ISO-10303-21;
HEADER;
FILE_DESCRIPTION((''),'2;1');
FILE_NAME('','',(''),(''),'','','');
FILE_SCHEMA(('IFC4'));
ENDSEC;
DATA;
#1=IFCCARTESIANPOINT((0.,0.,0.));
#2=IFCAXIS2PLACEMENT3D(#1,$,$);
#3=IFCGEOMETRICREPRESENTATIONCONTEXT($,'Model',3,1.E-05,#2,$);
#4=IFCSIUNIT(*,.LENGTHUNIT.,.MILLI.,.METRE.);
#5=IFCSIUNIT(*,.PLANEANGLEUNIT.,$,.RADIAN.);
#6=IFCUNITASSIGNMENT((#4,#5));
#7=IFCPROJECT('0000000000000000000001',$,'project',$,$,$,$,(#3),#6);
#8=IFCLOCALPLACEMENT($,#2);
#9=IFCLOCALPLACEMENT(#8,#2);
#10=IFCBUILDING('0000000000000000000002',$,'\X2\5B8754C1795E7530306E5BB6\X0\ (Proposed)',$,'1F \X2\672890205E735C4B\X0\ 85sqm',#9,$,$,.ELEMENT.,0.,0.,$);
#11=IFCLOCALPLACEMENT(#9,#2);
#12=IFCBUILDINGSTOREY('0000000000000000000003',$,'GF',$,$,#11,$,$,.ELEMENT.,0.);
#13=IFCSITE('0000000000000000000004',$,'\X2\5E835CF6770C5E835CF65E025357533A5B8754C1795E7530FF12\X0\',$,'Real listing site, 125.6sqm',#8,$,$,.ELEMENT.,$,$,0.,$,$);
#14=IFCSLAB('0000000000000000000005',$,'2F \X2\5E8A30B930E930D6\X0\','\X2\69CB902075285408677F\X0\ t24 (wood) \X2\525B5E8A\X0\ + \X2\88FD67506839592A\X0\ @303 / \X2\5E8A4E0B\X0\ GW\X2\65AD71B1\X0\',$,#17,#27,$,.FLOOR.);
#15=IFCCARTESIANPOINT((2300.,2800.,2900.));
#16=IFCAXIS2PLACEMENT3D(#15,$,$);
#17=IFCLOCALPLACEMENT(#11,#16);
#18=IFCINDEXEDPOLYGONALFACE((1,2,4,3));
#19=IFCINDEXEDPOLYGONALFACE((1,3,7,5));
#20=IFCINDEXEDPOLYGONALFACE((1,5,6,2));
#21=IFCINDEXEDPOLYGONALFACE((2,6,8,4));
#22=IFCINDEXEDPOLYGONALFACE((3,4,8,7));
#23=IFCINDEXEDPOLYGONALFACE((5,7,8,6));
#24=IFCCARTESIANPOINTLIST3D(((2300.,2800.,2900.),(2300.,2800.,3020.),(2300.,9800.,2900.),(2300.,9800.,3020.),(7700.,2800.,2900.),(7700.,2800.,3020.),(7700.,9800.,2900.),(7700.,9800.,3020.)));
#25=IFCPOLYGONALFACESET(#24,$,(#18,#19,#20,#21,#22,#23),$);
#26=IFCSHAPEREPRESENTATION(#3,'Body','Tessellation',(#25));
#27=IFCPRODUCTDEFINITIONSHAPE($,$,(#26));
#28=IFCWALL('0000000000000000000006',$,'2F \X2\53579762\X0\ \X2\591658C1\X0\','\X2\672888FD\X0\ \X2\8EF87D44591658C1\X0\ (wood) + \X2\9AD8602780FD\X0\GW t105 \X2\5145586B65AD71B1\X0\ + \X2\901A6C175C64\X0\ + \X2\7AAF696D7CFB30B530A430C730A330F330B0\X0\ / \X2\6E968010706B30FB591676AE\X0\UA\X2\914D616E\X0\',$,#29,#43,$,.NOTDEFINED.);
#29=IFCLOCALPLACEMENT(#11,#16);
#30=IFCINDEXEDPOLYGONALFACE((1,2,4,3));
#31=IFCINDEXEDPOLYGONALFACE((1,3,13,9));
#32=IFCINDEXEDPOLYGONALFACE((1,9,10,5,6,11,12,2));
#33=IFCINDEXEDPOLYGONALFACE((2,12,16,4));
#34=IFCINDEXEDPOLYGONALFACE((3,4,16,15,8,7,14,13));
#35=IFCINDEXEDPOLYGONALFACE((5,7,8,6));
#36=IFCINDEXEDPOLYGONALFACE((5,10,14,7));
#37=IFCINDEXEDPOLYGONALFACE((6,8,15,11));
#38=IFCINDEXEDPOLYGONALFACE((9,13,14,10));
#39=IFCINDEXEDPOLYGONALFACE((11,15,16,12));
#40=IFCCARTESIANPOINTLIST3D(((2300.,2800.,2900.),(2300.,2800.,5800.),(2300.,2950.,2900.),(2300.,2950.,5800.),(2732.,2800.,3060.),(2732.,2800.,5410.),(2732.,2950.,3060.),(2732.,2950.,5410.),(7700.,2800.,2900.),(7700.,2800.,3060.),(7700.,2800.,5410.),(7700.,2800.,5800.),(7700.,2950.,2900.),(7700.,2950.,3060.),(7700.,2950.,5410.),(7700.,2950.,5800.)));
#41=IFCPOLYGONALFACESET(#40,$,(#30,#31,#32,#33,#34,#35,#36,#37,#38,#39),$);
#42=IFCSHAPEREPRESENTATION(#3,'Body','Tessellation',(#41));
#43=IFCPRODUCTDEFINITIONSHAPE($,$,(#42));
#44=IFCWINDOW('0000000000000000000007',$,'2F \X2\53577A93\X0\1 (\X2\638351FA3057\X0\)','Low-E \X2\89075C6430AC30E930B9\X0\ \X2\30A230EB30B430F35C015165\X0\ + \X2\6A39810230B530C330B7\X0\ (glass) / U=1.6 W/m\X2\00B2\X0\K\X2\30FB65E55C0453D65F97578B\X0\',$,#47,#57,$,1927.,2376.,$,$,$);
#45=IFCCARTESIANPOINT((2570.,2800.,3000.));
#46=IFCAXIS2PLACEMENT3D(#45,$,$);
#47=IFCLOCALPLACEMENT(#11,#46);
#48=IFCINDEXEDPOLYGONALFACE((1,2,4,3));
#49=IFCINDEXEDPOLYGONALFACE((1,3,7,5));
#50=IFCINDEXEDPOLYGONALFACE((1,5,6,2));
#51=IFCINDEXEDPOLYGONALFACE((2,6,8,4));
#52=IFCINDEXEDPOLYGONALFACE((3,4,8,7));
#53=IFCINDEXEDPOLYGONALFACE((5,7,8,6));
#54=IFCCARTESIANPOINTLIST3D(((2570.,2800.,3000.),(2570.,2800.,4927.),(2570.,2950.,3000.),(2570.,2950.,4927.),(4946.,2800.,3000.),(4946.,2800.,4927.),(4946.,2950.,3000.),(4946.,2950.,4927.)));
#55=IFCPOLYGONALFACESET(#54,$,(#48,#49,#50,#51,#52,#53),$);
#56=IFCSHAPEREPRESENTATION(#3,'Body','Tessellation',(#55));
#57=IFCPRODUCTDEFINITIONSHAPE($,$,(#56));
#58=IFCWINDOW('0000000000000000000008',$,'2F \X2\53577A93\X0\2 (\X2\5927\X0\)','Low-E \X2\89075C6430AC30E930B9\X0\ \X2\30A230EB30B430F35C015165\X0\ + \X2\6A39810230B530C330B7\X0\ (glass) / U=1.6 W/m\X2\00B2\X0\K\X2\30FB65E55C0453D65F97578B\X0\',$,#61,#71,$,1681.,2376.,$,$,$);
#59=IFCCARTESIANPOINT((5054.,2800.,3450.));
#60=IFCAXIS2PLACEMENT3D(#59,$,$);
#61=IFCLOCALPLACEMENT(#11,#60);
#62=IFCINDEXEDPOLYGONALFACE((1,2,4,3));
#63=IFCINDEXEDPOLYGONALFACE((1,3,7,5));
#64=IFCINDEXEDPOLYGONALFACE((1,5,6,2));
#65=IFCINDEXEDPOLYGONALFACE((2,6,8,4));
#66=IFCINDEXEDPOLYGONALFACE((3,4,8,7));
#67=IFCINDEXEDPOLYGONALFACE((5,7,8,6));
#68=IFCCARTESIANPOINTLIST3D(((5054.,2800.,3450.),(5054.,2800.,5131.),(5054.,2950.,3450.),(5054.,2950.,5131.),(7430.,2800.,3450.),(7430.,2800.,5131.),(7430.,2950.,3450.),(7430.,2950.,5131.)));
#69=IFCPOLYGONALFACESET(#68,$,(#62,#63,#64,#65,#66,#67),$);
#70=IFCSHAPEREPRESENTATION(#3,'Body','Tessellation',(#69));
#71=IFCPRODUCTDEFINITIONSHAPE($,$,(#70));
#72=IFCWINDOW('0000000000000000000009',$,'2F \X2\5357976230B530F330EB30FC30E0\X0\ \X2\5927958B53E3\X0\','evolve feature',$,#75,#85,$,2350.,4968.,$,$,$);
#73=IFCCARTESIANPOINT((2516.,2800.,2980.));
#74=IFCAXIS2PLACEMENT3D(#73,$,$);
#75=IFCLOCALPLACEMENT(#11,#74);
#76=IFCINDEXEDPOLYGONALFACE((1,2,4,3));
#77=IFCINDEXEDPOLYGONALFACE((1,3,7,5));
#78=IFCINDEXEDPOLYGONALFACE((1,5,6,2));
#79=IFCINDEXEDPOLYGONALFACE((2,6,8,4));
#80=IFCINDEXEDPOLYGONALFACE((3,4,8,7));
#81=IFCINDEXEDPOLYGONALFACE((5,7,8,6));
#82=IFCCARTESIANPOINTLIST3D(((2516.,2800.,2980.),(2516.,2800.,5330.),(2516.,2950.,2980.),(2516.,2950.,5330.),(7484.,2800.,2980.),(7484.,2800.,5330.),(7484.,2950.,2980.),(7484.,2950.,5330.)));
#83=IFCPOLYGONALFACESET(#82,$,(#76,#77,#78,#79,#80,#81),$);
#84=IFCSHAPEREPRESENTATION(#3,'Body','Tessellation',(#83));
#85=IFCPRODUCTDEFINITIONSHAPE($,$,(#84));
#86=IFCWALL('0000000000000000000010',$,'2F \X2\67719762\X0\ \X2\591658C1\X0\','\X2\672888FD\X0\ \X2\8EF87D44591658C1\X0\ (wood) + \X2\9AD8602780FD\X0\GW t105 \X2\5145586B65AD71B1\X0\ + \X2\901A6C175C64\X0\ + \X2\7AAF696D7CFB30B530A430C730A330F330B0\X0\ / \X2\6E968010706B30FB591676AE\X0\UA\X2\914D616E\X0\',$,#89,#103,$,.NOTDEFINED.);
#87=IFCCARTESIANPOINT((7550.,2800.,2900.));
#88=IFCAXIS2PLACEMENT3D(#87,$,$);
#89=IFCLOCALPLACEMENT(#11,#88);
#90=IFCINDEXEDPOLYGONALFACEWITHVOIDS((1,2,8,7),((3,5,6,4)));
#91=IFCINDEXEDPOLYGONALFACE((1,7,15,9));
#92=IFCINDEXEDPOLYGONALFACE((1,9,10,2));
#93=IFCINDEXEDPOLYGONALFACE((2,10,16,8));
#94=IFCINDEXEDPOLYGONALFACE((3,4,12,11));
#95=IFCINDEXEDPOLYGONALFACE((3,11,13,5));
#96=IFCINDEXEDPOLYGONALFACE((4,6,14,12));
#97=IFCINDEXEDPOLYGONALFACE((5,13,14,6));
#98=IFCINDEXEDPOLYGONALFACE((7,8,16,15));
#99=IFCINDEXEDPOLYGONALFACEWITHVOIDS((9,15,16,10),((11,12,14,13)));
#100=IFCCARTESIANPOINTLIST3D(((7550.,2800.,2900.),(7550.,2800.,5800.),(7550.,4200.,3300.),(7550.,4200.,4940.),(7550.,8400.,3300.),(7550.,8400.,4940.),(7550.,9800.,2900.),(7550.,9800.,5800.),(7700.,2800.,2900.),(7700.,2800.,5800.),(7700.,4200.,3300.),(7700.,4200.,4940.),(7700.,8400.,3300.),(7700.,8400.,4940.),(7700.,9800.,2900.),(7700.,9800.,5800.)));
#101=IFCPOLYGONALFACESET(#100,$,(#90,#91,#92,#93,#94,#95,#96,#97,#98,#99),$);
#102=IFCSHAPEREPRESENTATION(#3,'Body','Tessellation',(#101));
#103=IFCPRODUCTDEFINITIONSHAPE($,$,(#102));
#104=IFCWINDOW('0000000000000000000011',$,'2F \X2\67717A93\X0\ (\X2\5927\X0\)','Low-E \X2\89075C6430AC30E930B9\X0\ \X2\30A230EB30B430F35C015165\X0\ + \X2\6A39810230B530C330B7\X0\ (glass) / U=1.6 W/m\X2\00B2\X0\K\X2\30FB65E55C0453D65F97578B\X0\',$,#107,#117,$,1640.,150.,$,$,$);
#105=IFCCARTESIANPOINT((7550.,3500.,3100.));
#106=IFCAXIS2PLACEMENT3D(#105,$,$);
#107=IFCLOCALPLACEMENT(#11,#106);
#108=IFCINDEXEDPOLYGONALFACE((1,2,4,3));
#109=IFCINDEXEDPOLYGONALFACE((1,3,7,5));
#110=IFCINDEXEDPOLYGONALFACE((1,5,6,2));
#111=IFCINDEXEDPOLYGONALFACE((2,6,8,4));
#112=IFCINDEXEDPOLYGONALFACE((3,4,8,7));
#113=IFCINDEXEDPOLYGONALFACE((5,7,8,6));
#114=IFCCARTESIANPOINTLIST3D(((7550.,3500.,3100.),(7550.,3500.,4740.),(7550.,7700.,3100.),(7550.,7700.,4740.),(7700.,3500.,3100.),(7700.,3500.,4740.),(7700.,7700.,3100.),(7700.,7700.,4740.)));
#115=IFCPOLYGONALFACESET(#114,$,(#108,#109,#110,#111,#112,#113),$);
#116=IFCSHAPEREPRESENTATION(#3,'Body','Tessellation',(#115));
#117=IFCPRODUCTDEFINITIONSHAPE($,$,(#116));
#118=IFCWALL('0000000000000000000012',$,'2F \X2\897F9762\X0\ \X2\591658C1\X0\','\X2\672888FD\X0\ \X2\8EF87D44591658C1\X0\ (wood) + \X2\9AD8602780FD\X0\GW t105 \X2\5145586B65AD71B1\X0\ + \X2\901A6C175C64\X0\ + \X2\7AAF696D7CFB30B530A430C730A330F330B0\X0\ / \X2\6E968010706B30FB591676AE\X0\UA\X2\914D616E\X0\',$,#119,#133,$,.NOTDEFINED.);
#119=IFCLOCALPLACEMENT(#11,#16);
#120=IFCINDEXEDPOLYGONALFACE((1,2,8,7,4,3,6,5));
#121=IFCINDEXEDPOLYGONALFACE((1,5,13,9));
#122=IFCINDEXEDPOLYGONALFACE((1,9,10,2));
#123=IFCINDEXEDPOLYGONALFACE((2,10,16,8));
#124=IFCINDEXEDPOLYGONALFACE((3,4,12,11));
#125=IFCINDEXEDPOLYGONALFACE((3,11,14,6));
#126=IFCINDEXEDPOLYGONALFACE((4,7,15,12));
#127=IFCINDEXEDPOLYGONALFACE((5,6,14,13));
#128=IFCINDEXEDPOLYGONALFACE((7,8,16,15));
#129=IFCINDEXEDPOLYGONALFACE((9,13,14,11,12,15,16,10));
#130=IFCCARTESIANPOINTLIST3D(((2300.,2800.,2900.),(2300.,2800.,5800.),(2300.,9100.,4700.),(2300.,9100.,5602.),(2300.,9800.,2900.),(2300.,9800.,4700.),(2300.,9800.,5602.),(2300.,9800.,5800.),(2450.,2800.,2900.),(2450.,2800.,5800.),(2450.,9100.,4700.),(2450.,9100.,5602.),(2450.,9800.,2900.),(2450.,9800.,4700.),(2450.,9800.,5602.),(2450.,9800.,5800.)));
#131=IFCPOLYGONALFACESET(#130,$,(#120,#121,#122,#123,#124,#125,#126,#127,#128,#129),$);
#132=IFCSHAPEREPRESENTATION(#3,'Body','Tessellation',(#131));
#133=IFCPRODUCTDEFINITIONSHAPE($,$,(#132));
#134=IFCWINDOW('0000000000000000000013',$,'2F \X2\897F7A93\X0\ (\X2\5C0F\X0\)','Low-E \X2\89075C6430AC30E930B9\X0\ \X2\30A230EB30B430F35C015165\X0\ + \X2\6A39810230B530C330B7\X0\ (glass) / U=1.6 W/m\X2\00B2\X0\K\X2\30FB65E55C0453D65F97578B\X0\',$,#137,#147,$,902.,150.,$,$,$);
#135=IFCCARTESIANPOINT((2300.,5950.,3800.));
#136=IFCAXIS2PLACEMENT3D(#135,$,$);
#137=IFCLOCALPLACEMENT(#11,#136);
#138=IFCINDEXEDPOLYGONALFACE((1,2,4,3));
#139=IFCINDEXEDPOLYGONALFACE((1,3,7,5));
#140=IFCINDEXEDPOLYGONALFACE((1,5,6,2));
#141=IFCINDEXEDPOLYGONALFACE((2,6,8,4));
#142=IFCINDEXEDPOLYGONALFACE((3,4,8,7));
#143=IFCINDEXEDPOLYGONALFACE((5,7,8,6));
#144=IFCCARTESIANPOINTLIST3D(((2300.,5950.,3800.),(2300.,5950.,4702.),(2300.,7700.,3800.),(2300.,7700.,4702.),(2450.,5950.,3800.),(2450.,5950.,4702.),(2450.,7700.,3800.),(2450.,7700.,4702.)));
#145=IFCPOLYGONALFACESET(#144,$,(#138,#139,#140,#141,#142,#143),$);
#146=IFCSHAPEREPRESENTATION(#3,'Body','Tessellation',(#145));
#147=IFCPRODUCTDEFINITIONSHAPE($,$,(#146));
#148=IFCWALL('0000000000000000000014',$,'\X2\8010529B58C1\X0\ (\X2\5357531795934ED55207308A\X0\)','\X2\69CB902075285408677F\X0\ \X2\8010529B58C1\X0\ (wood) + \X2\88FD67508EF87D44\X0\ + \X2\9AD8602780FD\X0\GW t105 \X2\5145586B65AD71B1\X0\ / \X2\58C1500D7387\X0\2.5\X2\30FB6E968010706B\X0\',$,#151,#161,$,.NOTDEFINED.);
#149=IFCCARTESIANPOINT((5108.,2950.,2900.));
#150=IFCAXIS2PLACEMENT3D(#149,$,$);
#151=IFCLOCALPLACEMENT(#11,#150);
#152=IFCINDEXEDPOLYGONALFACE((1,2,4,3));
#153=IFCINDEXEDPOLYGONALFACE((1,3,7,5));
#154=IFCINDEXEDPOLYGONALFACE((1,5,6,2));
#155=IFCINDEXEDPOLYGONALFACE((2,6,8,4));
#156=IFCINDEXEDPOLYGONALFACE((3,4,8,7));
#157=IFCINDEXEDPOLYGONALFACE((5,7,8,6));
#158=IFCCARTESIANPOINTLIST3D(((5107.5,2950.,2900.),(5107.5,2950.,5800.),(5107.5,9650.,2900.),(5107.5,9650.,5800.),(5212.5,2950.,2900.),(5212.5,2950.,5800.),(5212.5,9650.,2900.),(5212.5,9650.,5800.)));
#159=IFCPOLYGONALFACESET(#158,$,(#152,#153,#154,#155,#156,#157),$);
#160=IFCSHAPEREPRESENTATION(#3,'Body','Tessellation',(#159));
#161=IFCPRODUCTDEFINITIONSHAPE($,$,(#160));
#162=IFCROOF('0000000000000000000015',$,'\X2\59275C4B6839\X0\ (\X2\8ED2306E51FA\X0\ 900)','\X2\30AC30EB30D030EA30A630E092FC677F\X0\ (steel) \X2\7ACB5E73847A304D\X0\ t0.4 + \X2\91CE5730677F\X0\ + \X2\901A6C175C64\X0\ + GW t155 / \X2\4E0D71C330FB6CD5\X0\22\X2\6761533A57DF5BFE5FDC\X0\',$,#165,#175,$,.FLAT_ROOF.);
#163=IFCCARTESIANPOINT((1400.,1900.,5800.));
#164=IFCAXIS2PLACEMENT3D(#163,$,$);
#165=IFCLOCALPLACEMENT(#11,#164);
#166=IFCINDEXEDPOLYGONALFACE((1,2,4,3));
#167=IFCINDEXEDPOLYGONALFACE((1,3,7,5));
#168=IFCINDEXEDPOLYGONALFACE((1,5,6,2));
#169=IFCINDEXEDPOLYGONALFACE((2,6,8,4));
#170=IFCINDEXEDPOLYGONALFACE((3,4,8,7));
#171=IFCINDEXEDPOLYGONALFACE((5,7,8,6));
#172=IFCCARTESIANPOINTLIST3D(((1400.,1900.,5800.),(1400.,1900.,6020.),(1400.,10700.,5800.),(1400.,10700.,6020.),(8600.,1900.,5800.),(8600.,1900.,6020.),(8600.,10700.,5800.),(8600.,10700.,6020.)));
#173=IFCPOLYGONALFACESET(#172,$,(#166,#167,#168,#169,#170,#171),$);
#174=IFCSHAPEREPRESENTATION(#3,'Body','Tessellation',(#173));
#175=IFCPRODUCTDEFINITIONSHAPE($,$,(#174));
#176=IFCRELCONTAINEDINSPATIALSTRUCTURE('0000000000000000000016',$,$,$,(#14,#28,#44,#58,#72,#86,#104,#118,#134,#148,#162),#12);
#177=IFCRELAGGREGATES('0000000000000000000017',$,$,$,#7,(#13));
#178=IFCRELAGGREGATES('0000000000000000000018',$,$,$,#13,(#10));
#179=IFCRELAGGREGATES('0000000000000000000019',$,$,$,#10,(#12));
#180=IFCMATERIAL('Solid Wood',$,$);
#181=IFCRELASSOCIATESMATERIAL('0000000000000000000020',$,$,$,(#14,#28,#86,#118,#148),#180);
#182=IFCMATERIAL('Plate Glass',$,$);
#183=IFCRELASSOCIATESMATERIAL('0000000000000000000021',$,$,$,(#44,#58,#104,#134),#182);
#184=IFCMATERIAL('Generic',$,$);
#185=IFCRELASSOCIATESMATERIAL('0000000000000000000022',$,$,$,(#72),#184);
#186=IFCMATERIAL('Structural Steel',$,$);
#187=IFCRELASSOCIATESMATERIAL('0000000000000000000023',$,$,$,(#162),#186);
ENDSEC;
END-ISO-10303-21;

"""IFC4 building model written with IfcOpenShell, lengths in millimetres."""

from ifc_helpers import new_model, si_unit, frame, frame_2d, origin, place, context, project, spatial, rectangle, extrude, material, element, fill, save


model = new_model("IFC4")

# Units and contexts
model_context = context("Model", 3, precision=1e-05, world=origin())
ifc_project = project(units=[si_unit("LENGTHUNIT", "METRE", prefix="MILLI"), si_unit("PLANEANGLEUNIT", "RADIAN")], contexts=[model_context])

# Site, building, storey
site_placement = place(None, origin())
site = spatial("IfcSite", under=ifc_project, at=site_placement, Name="広島県広島市南区宇品神田２", ObjectType="Real listing site, 125.6sqm", CompositionType="ELEMENT", RefElevation=0.0)
building_placement = place(site_placement, origin())
building = spatial("IfcBuilding", under=site, at=building_placement, Name="宇品神田の家 (Proposed)", ObjectType="1F 木造平屋 85sqm", CompositionType="ELEMENT", ElevationOfRefHeight=0.0, ElevationOfTerrain=0.0)
storey_placement = place(building_placement, origin())
storey = spatial("IfcBuildingStorey", under=building, at=storey_placement, Name="GF", CompositionType="ELEMENT", Elevation=0.0)

# Slab
ifc_material_1 = material(Name="Solid Wood")
slab_placement = place(storey_placement, frame((2300.0, 2800.0, 2900.0)))
element("IfcSlab", 1, at=slab_placement, inside=storey, material=ifc_material_1, Name="2F 床スラブ", Description="構造用合板 t24 (wood) 剛床 + 製材根太 @303 / 床下 GW断熱", PredefinedType="FLOOR", context=model_context, shape_type="SweptSolid", body=[
    extrude(rectangle(XDim=5400.0, YDim=7000.0, at=frame_2d((2700.0, 3500.0))), frame((2300.0, 2800.0, 2900.0)), (0.0, 0.0, 1.0), 120.0),
])

# Wall, openings, windows
wall_1_placement = place(storey_placement, frame((2300.0, 2800.0, 2900.0)))
wall_1 = element("IfcWall", 2, at=wall_1_placement, inside=storey, material=ifc_material_1, Name="2F 南面 外壁", Description="木製 軸組外壁 (wood) + 高性能GW t105 充填断熱 + 通気層 + 窯業系サイディング / 準耐火・外皮UA配慮", PredefinedType="NOTDEFINED", context=model_context, shape_type="SweptSolid", body=[
    extrude(rectangle(XDim=5400.0, YDim=150.0, at=frame_2d((2700.0, 75.0))), frame((2300.0, 2800.0, 2900.0)), (0.0, 0.0, 1.0), 2900.0),
])
opening_1_placement = place(storey_placement, frame((2570.0, 2800.0, 3000.0)))
opening_1 = element("IfcOpeningElement", 3, at=opening_1_placement, cuts=wall_1, PredefinedType="NOTDEFINED", context=model_context, shape_type="SweptSolid", body=[
    extrude(rectangle(XDim=2376.0, YDim=150.0, at=frame_2d((1188.0, 75.0))), frame((2570.0, 2800.0, 3000.0)), (0.0, 0.0, 1.0), 1927.0),
])
opening_2_placement = place(storey_placement, frame((5054.0, 2800.0, 3450.0)))
opening_2 = element("IfcOpeningElement", 4, at=opening_2_placement, cuts=wall_1, PredefinedType="NOTDEFINED", context=model_context, shape_type="SweptSolid", body=[
    extrude(rectangle(XDim=2376.0, YDim=150.0, at=frame_2d((1188.0, 75.0))), frame((5054.0, 2800.0, 3450.0)), (0.0, 0.0, 1.0), 1681.0),
])
opening_3_placement = place(storey_placement, frame((2516.0, 2800.0, 2980.0)))
opening_3 = element("IfcOpeningElement", 5, at=opening_3_placement, cuts=wall_1, PredefinedType="NOTDEFINED", context=model_context, shape_type="SweptSolid", body=[
    extrude(rectangle(XDim=4968.0, YDim=150.0, at=frame_2d((2484.0, 75.0))), frame((2516.0, 2800.0, 2980.0)), (0.0, 0.0, 1.0), 2350.0),
])
ifc_material_2 = material(Name="Plate Glass")
window_1_placement = place(storey_placement, frame((2570.0, 2800.0, 3000.0)))
window_1 = element("IfcWindow", 6, at=window_1_placement, inside=storey, material=ifc_material_2, Name="2F 南窓1 (掃出し)", Description="Low-E 複層ガラス アルゴン封入 + 樹脂サッシ (glass) / U=1.6 W/m²K・日射取得型", OverallHeight=1927.0, OverallWidth=2376.0, context=model_context, shape_type="SweptSolid", body=[
    extrude(rectangle(XDim=2376.0, YDim=150.0, at=frame_2d((1188.0, 75.0))), frame((2570.0, 2800.0, 3000.0)), (0.0, 0.0, 1.0), 1927.0),
])
fill(opening_1, window_1)
window_2_placement = place(storey_placement, frame((5054.0, 2800.0, 3450.0)))
window_2 = element("IfcWindow", 7, at=window_2_placement, inside=storey, material=ifc_material_2, Name="2F 南窓2 (大)", Description="Low-E 複層ガラス アルゴン封入 + 樹脂サッシ (glass) / U=1.6 W/m²K・日射取得型", OverallHeight=1681.0, OverallWidth=2376.0, context=model_context, shape_type="SweptSolid", body=[
    extrude(rectangle(XDim=2376.0, YDim=150.0, at=frame_2d((1188.0, 75.0))), frame((5054.0, 2800.0, 3450.0)), (0.0, 0.0, 1.0), 1681.0),
])
fill(opening_2, window_2)
ifc_material_3 = material(Name="Generic")
window_3_placement = place(storey_placement, frame((2516.0, 2800.0, 2980.0)))
window_3 = element("IfcWindow", 8, at=window_3_placement, inside=storey, material=ifc_material_3, Name="2F 南面サンルーム 大開口", Description="evolve feature", OverallHeight=2350.0, OverallWidth=4968.0, context=model_context, shape_type="SweptSolid", body=[
    extrude(rectangle(XDim=4968.0, YDim=150.0, at=frame_2d((2484.0, 75.0))), frame((2516.0, 2800.0, 2980.0)), (0.0, 0.0, 1.0), 2350.0),
])
fill(opening_3, window_3)

# Walls, openings, windows
wall_2_placement = place(storey_placement, frame((7550.0, 2800.0, 2900.0)))
wall_2 = element("IfcWall", 9, at=wall_2_placement, inside=storey, material=ifc_material_1, Name="2F 東面 外壁", Description="木製 軸組外壁 (wood) + 高性能GW t105 充填断熱 + 通気層 + 窯業系サイディング / 準耐火・外皮UA配慮", PredefinedType="NOTDEFINED", context=model_context, shape_type="SweptSolid", body=[
    extrude(rectangle(XDim=150.0, YDim=7000.0, at=frame_2d((75.0, 3500.0))), frame((7550.0, 2800.0, 2900.0)), (0.0, 0.0, 1.0), 2900.0),
])
opening_4_placement = place(storey_placement, frame((7550.0, 3500.0, 3100.0)))
opening_4 = element("IfcOpeningElement", 10, at=opening_4_placement, cuts=wall_2, PredefinedType="NOTDEFINED", context=model_context, shape_type="SweptSolid", body=[
    extrude(rectangle(XDim=150.0, YDim=4200.0, at=frame_2d((75.0, 2100.0))), frame((7550.0, 3500.0, 3100.0)), (0.0, 0.0, 1.0), 1640.0),
])
window_4_placement = place(storey_placement, frame((7550.0, 3500.0, 3100.0)))
window_4 = element("IfcWindow", 11, at=window_4_placement, inside=storey, material=ifc_material_2, Name="2F 東窓 (大)", Description="Low-E 複層ガラス アルゴン封入 + 樹脂サッシ (glass) / U=1.6 W/m²K・日射取得型", OverallHeight=1640.0, OverallWidth=150.0, context=model_context, shape_type="SweptSolid", body=[
    extrude(rectangle(XDim=150.0, YDim=4200.0, at=frame_2d((75.0, 2100.0))), frame((7550.0, 3500.0, 3100.0)), (0.0, 0.0, 1.0), 1640.0),
])
fill(opening_4, window_4)
wall_3_placement = place(storey_placement, frame((2300.0, 2800.0, 2900.0)))
wall_3 = element("IfcWall", 12, at=wall_3_placement, inside=storey, material=ifc_material_1, Name="2F 西面 外壁", Description="木製 軸組外壁 (wood) + 高性能GW t105 充填断熱 + 通気層 + 窯業系サイディング / 準耐火・外皮UA配慮", PredefinedType="NOTDEFINED", context=model_context, shape_type="SweptSolid", body=[
    extrude(rectangle(XDim=150.0, YDim=7000.0, at=frame_2d((75.0, 3500.0))), frame((2300.0, 2800.0, 2900.0)), (0.0, 0.0, 1.0), 2900.0),
])
opening_5_placement = place(storey_placement, frame((2300.0, 5950.0, 3800.0)))
opening_5 = element("IfcOpeningElement", 13, at=opening_5_placement, cuts=wall_3, PredefinedType="NOTDEFINED", context=model_context, shape_type="SweptSolid", body=[
    extrude(rectangle(XDim=150.0, YDim=1750.0, at=frame_2d((75.0, 875.0))), frame((2300.0, 5950.0, 3800.0)), (0.0, 0.0, 1.0), 902.0),
])
window_5_placement = place(storey_placement, frame((2300.0, 5950.0, 3800.0)))
window_5 = element("IfcWindow", 14, at=window_5_placement, inside=storey, material=ifc_material_2, Name="2F 西窓 (小)", Description="Low-E 複層ガラス アルゴン封入 + 樹脂サッシ (glass) / U=1.6 W/m²K・日射取得型", OverallHeight=902.0, OverallWidth=150.0, context=model_context, shape_type="SweptSolid", body=[
    extrude(rectangle(XDim=150.0, YDim=1750.0, at=frame_2d((75.0, 875.0))), frame((2300.0, 5950.0, 3800.0)), (0.0, 0.0, 1.0), 902.0),
])
fill(opening_5, window_5)

# Wall
wall_4_placement = place(storey_placement, frame((5108.0, 2950.0, 2900.0)))
element("IfcWall", 15, at=wall_4_placement, inside=storey, material=ifc_material_1, Name="耐力壁 (南北間仕切り)", Description="構造用合板 耐力壁 (wood) + 製材軸組 + 高性能GW t105 充填断熱 / 壁倍率2.5・準耐火", PredefinedType="NOTDEFINED", context=model_context, shape_type="SweptSolid", body=[
    extrude(rectangle(XDim=105.0, YDim=6700.0, at=frame_2d((52.0, 3350.0))), frame((5108.0, 2950.0, 2900.0)), (0.0, 0.0, 1.0), 2900.0),
])

# Roof
ifc_material_4 = material(Name="Structural Steel")
roof_1_placement = place(storey_placement, frame((1400.0, 1900.0, 5800.0)))
element("IfcRoof", 16, at=roof_1_placement, inside=storey, material=ifc_material_4, Name="大屋根 (軒の出 900)", Description="ガルバリウム鋼板 (steel) 立平葺き t0.4 + 野地板 + 通気層 + GW t155 / 不燃・法22条区域対応", PredefinedType="FLAT_ROOF", context=model_context, shape_type="SweptSolid", body=[
    extrude(rectangle(XDim=7200.0, YDim=8800.0, at=frame_2d((3600.0, 4400.0))), frame((1400.0, 1900.0, 5800.0)), (0.0, 0.0, 1.0), 220.0),
])

save(model, "model.ifc")
